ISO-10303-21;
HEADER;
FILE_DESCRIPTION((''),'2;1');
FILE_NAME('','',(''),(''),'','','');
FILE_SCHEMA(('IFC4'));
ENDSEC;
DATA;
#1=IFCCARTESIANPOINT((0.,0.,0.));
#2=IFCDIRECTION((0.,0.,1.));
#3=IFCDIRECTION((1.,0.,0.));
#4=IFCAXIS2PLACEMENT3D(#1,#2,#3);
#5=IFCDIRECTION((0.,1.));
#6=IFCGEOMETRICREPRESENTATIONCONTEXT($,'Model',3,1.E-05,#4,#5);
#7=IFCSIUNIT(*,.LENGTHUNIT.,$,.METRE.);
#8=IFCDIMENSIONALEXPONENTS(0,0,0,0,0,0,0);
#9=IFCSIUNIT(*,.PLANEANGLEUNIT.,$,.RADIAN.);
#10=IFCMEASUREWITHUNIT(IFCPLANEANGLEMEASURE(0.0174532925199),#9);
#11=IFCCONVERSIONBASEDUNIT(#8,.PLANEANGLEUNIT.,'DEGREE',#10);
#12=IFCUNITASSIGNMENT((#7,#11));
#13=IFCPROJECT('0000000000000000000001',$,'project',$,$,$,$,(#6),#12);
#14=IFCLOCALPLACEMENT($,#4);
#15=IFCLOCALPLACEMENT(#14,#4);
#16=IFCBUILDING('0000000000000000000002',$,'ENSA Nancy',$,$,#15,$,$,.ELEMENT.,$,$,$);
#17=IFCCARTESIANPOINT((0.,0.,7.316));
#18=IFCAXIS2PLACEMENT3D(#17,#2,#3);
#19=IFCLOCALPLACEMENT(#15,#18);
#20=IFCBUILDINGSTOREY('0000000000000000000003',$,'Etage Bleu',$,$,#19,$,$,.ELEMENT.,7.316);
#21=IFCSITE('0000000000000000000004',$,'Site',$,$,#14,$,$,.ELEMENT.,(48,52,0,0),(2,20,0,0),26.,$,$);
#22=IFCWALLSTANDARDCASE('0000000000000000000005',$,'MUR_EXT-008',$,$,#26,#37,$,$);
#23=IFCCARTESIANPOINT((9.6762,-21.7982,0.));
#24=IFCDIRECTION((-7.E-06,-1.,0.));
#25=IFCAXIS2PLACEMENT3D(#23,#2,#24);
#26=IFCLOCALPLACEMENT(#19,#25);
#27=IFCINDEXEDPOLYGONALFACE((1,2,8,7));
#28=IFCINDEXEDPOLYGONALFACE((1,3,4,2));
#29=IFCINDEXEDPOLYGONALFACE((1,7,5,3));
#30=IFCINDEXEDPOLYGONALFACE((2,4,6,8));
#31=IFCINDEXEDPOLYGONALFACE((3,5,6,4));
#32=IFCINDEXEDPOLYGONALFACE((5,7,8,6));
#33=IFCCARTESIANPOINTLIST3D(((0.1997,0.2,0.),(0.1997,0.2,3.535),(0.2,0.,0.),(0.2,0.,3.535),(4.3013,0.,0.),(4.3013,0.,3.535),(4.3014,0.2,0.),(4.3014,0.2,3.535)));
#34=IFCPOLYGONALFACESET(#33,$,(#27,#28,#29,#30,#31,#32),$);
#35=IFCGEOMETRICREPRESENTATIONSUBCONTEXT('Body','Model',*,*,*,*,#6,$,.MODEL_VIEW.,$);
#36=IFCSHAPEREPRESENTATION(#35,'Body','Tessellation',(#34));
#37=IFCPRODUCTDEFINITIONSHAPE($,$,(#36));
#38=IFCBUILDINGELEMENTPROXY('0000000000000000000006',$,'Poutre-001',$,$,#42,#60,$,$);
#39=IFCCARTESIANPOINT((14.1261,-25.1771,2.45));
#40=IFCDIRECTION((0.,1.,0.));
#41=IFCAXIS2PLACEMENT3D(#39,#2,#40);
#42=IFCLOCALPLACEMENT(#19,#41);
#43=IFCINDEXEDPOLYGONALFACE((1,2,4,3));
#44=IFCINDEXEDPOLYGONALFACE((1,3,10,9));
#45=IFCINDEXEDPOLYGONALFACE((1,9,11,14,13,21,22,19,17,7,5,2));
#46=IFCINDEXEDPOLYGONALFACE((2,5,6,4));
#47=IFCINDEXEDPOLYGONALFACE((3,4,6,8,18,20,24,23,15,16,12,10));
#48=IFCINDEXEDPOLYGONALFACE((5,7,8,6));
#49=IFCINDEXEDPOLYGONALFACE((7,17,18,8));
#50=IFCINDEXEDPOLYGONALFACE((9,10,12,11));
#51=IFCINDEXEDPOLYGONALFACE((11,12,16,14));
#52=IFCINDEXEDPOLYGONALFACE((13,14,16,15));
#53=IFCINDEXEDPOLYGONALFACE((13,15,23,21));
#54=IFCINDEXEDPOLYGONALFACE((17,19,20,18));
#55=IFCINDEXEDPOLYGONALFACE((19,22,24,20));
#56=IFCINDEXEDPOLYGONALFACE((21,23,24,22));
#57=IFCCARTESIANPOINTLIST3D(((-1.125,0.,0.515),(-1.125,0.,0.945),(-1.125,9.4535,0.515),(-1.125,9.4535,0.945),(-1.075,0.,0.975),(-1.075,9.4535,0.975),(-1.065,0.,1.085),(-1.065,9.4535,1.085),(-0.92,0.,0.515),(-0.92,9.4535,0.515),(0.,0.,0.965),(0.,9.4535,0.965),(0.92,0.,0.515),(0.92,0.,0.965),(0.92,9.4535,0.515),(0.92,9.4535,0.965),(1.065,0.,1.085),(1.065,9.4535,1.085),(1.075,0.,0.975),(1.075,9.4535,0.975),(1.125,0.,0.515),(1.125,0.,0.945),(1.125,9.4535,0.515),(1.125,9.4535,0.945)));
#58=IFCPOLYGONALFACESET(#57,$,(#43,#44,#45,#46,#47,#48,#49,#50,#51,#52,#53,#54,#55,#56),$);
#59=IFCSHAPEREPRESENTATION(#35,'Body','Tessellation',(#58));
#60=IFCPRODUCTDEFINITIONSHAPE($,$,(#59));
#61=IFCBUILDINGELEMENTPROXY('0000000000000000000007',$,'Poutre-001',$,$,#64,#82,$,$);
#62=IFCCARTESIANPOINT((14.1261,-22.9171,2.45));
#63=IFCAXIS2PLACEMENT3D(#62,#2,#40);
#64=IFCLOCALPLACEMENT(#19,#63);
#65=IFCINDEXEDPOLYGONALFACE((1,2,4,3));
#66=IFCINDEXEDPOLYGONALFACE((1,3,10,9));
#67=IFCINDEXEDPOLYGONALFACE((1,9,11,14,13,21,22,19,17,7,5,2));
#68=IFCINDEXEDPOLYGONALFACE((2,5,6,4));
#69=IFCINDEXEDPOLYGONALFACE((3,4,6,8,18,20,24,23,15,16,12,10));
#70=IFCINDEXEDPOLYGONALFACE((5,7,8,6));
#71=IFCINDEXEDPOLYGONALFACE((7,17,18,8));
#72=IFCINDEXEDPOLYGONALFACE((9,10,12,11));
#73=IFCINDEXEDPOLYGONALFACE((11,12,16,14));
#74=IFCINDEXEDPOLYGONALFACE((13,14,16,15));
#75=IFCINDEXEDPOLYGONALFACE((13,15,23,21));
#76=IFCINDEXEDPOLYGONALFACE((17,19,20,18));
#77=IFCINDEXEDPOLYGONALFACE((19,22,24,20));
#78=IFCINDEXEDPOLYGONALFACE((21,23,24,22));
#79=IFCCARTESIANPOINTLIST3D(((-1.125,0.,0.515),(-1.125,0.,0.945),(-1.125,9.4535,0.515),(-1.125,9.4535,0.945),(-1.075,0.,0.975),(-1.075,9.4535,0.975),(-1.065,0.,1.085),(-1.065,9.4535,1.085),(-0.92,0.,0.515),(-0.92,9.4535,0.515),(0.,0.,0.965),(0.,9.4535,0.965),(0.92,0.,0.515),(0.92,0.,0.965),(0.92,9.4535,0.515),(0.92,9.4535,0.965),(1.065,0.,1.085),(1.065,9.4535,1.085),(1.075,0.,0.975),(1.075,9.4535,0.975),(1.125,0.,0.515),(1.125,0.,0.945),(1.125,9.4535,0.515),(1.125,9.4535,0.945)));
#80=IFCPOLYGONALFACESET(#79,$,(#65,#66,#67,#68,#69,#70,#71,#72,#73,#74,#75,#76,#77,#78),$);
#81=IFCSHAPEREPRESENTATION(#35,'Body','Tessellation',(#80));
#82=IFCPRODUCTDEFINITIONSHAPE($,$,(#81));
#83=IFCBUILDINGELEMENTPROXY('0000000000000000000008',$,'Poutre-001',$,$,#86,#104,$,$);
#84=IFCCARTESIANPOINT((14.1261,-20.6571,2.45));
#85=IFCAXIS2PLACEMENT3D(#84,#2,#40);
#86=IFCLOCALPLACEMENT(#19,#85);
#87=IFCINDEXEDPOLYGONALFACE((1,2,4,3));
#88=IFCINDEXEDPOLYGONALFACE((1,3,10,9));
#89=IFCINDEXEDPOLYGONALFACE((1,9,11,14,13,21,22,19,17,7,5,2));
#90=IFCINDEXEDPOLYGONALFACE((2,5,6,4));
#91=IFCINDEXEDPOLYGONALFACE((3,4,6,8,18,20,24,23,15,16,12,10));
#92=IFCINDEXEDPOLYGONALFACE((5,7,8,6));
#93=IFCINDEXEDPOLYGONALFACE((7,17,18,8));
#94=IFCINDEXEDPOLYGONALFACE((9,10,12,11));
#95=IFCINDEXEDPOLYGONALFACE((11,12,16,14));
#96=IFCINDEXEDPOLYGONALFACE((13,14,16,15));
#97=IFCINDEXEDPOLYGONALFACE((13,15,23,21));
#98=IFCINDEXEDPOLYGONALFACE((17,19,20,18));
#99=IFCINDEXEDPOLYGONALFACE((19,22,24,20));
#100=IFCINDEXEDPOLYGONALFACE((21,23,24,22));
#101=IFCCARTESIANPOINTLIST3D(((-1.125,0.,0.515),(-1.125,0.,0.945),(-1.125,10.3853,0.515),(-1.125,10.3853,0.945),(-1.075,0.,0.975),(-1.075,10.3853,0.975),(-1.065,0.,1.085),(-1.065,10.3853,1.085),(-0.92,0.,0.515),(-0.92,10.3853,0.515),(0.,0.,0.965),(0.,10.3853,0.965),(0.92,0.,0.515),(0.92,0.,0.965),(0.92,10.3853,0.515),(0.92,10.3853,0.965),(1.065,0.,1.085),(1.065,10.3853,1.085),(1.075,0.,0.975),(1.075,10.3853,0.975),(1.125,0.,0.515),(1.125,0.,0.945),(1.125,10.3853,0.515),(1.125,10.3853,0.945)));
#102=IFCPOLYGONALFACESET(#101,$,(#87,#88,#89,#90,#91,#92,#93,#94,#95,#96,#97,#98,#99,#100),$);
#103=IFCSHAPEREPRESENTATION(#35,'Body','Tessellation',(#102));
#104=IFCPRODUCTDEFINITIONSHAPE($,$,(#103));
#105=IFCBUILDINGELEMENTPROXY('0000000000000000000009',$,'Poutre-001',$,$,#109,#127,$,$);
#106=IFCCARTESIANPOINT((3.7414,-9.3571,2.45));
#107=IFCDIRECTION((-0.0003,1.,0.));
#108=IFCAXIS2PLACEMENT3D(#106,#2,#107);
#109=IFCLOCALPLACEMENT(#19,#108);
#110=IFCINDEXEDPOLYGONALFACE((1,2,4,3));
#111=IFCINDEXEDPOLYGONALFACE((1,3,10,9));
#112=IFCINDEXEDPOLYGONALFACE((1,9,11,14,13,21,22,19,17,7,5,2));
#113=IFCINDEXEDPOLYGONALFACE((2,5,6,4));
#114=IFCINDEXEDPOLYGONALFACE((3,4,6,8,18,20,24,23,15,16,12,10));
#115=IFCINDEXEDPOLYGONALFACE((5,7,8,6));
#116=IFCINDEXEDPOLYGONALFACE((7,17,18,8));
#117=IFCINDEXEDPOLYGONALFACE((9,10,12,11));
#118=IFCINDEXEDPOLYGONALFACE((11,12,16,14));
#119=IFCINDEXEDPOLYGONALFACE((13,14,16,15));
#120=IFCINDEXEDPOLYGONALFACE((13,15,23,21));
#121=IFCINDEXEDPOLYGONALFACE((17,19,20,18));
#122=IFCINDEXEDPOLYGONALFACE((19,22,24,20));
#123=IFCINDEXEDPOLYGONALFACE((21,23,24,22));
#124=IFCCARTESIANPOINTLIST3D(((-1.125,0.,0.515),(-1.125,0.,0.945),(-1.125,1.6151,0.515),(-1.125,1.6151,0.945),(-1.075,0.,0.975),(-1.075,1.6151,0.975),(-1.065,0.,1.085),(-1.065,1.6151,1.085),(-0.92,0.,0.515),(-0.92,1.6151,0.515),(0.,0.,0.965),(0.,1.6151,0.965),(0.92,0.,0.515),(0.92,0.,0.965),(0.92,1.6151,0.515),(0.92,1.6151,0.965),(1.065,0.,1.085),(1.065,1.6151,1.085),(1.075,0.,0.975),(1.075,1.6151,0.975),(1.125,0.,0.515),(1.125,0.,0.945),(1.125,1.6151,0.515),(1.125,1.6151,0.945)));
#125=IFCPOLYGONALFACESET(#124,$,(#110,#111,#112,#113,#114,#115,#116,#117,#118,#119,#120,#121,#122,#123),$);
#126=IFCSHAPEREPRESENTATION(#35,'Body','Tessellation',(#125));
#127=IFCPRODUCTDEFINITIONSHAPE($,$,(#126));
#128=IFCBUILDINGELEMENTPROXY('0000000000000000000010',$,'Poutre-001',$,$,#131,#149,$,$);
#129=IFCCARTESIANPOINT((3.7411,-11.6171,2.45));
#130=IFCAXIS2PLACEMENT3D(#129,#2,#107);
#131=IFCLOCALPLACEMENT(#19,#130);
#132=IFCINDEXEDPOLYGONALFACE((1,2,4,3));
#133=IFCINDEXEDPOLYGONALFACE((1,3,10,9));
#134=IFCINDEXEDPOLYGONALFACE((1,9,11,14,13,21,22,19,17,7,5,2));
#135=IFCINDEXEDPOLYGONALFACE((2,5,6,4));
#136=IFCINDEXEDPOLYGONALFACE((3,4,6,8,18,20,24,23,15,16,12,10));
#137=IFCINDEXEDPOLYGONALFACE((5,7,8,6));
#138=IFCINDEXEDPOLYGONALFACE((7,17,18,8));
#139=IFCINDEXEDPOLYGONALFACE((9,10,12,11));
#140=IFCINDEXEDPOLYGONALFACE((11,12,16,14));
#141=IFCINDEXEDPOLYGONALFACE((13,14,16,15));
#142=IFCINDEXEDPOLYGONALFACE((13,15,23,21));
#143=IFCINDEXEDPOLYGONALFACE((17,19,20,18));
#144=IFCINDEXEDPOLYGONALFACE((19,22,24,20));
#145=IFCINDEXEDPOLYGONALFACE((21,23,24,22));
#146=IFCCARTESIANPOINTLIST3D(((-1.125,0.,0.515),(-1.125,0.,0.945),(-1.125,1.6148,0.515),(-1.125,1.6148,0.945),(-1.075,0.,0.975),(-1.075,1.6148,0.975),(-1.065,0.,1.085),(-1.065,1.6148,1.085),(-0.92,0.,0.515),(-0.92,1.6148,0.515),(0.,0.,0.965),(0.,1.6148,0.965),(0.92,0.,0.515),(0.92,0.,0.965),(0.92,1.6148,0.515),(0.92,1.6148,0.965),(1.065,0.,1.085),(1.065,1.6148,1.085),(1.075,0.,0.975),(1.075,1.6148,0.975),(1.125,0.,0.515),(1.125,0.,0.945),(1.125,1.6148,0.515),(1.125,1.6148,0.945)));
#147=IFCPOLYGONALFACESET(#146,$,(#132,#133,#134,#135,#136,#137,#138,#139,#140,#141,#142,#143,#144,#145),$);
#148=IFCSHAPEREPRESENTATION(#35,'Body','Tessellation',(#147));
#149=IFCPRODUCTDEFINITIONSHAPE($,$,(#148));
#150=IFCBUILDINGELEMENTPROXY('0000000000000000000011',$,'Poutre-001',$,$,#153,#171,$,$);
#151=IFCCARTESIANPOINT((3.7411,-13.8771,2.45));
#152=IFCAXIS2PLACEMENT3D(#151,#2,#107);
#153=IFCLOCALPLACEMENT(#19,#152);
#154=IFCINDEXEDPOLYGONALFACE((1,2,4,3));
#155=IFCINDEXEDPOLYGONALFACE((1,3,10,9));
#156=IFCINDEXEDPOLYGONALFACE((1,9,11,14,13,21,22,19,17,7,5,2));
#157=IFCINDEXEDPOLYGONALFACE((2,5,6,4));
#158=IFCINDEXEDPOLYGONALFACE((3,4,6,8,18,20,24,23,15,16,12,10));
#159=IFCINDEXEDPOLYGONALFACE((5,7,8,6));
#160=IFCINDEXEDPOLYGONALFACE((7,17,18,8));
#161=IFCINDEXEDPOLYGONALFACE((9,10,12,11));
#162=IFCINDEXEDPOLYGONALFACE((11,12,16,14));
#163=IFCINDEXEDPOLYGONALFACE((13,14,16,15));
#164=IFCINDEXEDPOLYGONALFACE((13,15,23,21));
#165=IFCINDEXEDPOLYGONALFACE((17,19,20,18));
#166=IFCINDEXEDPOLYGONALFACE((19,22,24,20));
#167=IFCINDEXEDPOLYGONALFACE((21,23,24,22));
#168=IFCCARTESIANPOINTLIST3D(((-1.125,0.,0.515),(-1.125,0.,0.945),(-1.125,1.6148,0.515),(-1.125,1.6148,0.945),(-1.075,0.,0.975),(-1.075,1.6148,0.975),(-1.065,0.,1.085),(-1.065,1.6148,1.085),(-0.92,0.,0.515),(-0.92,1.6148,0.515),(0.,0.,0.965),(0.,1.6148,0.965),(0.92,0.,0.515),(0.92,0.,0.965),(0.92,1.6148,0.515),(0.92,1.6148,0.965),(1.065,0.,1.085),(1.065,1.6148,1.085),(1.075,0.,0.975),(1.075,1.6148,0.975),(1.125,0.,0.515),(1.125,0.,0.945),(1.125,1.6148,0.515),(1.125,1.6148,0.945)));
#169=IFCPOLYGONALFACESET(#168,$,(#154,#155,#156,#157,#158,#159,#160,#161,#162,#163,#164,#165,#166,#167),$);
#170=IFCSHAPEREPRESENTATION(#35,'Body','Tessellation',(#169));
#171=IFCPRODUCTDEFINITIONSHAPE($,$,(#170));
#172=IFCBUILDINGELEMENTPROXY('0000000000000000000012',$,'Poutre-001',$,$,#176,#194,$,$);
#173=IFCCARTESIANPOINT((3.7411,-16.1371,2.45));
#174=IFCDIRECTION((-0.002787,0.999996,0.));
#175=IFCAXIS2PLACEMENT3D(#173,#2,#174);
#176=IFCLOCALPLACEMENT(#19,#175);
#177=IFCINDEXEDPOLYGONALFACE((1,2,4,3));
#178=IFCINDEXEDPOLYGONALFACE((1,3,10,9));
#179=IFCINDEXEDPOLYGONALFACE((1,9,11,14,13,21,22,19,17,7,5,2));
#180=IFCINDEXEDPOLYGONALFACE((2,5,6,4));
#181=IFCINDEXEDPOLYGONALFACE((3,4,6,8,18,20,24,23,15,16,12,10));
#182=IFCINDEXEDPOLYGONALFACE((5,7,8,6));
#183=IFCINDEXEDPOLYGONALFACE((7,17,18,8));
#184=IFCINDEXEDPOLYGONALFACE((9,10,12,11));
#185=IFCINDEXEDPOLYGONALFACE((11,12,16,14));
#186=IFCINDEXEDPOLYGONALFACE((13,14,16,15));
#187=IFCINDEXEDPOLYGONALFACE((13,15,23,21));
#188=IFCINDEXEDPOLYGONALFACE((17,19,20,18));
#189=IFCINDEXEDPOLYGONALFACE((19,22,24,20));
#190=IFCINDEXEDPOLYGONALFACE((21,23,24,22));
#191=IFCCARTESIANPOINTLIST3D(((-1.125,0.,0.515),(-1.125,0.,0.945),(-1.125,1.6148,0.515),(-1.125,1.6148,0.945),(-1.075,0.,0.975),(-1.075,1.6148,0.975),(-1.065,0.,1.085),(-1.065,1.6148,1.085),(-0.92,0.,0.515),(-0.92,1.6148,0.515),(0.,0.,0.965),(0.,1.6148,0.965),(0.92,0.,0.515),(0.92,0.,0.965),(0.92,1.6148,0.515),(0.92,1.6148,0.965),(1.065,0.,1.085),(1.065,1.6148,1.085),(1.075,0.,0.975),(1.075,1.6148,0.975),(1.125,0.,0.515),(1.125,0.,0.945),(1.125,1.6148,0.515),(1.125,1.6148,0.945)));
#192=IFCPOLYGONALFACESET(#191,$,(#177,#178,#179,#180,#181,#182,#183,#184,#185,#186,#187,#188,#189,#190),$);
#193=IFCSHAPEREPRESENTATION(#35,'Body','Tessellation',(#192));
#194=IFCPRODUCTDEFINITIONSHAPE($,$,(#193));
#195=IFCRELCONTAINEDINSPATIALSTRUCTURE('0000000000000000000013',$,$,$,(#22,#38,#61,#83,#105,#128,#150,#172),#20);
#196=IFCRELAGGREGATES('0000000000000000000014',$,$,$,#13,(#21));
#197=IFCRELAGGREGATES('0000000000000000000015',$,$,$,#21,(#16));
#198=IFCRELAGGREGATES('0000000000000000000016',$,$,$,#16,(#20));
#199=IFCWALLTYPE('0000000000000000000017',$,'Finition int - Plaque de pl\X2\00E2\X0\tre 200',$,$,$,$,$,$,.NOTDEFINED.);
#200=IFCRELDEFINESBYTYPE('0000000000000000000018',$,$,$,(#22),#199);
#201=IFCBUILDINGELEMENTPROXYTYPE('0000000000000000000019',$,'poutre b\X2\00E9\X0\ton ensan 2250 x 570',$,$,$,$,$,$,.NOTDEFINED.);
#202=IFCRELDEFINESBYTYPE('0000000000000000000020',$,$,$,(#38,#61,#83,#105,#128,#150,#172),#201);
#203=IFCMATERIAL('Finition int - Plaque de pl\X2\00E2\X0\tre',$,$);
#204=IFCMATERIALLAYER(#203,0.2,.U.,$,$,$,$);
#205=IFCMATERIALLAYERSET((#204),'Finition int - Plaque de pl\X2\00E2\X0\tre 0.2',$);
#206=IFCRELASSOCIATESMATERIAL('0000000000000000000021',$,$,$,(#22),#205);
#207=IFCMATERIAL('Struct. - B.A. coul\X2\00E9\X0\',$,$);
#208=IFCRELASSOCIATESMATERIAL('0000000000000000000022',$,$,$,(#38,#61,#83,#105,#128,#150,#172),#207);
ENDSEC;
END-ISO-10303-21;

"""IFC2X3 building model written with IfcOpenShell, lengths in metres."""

from ifc_helpers import new_model, entity, si_unit, converted_unit, direction, frame, origin_with_axes, place, context, subcontext, project, spatial, polyline, outline, extrude, material, layer, layer_set, layer_usage, type_object, element, save


model = new_model("IFC2X3")

# Units and contexts
model_context = context("Model", 3, precision=1e-05, world=origin_with_axes(), true_north=direction((0.0, 1.0)))
body_context = subcontext(model_context, "Body", "Model", "MODEL_VIEW")
ifc_project = project(units=[si_unit("LENGTHUNIT", "METRE"), converted_unit("PLANEANGLEUNIT", "DEGREE", entity("IfcPlaneAngleMeasure", 0.0174532925199), si_unit("PLANEANGLEUNIT", "RADIAN"), dimensions=[0, 0, 0, 0, 0, 0, 0])], contexts=[model_context])

# Site, building, storey
site_placement = place(None, origin_with_axes())
site = spatial("IfcSite", under=ifc_project, at=site_placement, Name="Site", CompositionType="ELEMENT", RefLatitude=(48, 52, 0, 0), RefLongitude=(2, 20, 0, 0), RefElevation=26.0)
building_placement = place(site_placement, origin_with_axes())
building = spatial("IfcBuilding", under=site, at=building_placement, Name="ENSA Nancy", CompositionType="ELEMENT")
storey_placement = place(building_placement, frame((0.0, 0.0, 7.316), z_axis=(0.0, 0.0, 1.0), x_axis=(1.0, 0.0, 0.0)))
storey = spatial("IfcBuildingStorey", under=building, at=storey_placement, Name="Etage Bleu", CompositionType="ELEMENT", Elevation=7.316)

# Shared definitions
ifc_material_1 = material(Name="Finition int - Plaque de plâtre")
ifc_layer_1 = layer(ifc_material_1, 0.2, ventilated="UNKNOWN")
ifc_layer_set_1 = layer_set([ifc_layer_1], Name="Finition int - Plaque de plâtre 0.2")
wall_type_1 = type_object("IfcWallType", Name="Finition int - Plaque de plâtre 200", PredefinedType="NOTDEFINED")

# Wall
ifc_layer_usage_1 = layer_usage(ifc_layer_set_1, "AXIS2", "POSITIVE", 0.0)
wall_1_placement = place(storey_placement, frame((9.6762, -21.7982, 0.0), z_axis=(0.0, 0.0, 1.0), x_axis=(-0.000007, -1.0, 0.0)))
element("IfcWallStandardCase", 1, at=wall_1_placement, inside=storey, type_object=wall_type_1, material=ifc_layer_usage_1, Name="MUR_EXT-008", context=body_context, shape_type="SweptSolid", body=[
    extrude(outline(polyline([(0.2, 0.0), (4.3013, 0.0), (4.3014, 0.2), (0.1997, 0.2), (0.2, 0.0)])), origin_with_axes(), (0.0, 0.0, 1.0), 3.535),
])

# Building element proxies
ifc_material_2 = material(Name="Struct. - B.A. coulé")
building_element_proxy_type_1 = type_object("IfcBuildingElementProxyType", Name="poutre béton ensan 2250 x 570", PredefinedType="NOTDEFINED")
for number, where, z_axis, x_axis, name in (
    (2, (14.1261, -25.1771, 2.45), (0.0, 0.0, 1.0), (0.0, 1.0, 0.0), "Poutre-001"),
    (3, (14.1261, -22.9171, 2.45), (0.0, 0.0, 1.0), (0.0, 1.0, 0.0), "Poutre-001"),
):
    element("IfcBuildingElementProxy", number, at=place(storey_placement, frame(where, z_axis=z_axis, x_axis=x_axis)), inside=storey, type_object=building_element_proxy_type_1, material=ifc_material_2, Name=name, context=body_context, shape_type="SweptSolid", body=[
        extrude(outline(polyline([(-1.065, 1.085), (-1.075, 0.975), (-1.125, 0.945), (-1.125, 0.515), (-0.92, 0.515), (0.0, 0.965), (0.92, 0.965), (0.92, 0.515), (1.125, 0.515), (1.125, 0.945), (1.075, 0.975), (1.065, 1.085), (-1.065, 1.085)])), frame((0.0, 9.4535, 0.0), z_axis=(0.0, -1.0, 0.0), x_axis=(1.0, 0.0, 0.0)), (0.0, 0.0, 1.0), 9.4535),
    ])
proxy_1_placement = place(storey_placement, frame((14.1261, -20.6571, 2.45), z_axis=(0.0, 0.0, 1.0), x_axis=(0.0, 1.0, 0.0)))
element("IfcBuildingElementProxy", 4, at=proxy_1_placement, inside=storey, type_object=building_element_proxy_type_1, material=ifc_material_2, Name="Poutre-001", context=body_context, shape_type="SweptSolid", body=[
    extrude(outline(polyline([(-1.065, 1.085), (-1.075, 0.975), (-1.125, 0.945), (-1.125, 0.515), (-0.92, 0.515), (0.0, 0.965), (0.92, 0.965), (0.92, 0.515), (1.125, 0.515), (1.125, 0.945), (1.075, 0.975), (1.065, 1.085), (-1.065, 1.085)])), frame((0.0, 10.3853, 0.0), z_axis=(0.0, -1.0, 0.0), x_axis=(1.0, 0.0, 0.0)), (0.0, 0.0, 1.0), 10.3853),
])
proxy_2_placement = place(storey_placement, frame((3.7414, -9.3571, 2.45), z_axis=(0.0, 0.0, 1.0), x_axis=(-0.0003, 1.0, 0.0)))
element("IfcBuildingElementProxy", 5, at=proxy_2_placement, inside=storey, type_object=building_element_proxy_type_1, material=ifc_material_2, Name="Poutre-001", context=body_context, shape_type="SweptSolid", body=[
    extrude(outline(polyline([(-1.065, 1.085), (-1.075, 0.975), (-1.125, 0.945), (-1.125, 0.515), (-0.92, 0.515), (0.0, 0.965), (0.92, 0.965), (0.92, 0.515), (1.125, 0.515), (1.125, 0.945), (1.075, 0.975), (1.065, 1.085), (-1.065, 1.085)])), frame((0.0, 1.6151, 0.0), z_axis=(0.0, -1.0, 0.0), x_axis=(1.0, 0.0, 0.0)), (0.0, 0.0, 1.0), 1.6151),
])
for number, where, z_axis, x_axis, name in (
    (6, (3.7411, -11.6171, 2.45), (0.0, 0.0, 1.0), (-0.0003, 1.0, 0.0), "Poutre-001"),
    (7, (3.7411, -13.8771, 2.45), (0.0, 0.0, 1.0), (-0.0003, 1.0, 0.0), "Poutre-001"),
):
    element("IfcBuildingElementProxy", number, at=place(storey_placement, frame(where, z_axis=z_axis, x_axis=x_axis)), inside=storey, type_object=building_element_proxy_type_1, material=ifc_material_2, Name=name, context=body_context, shape_type="SweptSolid", body=[
        extrude(outline(polyline([(-1.065, 1.085), (-1.075, 0.975), (-1.125, 0.945), (-1.125, 0.515), (-0.92, 0.515), (0.0, 0.965), (0.92, 0.965), (0.92, 0.515), (1.125, 0.515), (1.125, 0.945), (1.075, 0.975), (1.065, 1.085), (-1.065, 1.085)])), frame((0.0, 1.6148, 0.0), z_axis=(0.0, -1.0, 0.0), x_axis=(1.0, 0.0, 0.0)), (0.0, 0.0, 1.0), 1.6148),
    ])
proxy_3_placement = place(storey_placement, frame((3.7411, -16.1371, 2.45), z_axis=(0.0, 0.0, 1.0), x_axis=(-0.002787, 0.999996, 0.0)))
element("IfcBuildingElementProxy", 8, at=proxy_3_placement, inside=storey, type_object=building_element_proxy_type_1, material=ifc_material_2, Name="Poutre-001", context=body_context, shape_type="SweptSolid", body=[
    extrude(outline(polyline([(-1.065, 1.085), (-1.075, 0.975), (-1.125, 0.945), (-1.125, 0.515), (-0.92, 0.515), (0.0, 0.965), (0.92, 0.965), (0.92, 0.515), (1.125, 0.515), (1.125, 0.945), (1.075, 0.975), (1.065, 1.085), (-1.065, 1.085)])), frame((0.0, 1.6148, 0.0), z_axis=(0.0, -1.0, 0.0), x_axis=(1.0, 0.0, 0.0)), (0.0, 0.0, 1.0), 1.6148),
])

save(model, "model.ifc")
